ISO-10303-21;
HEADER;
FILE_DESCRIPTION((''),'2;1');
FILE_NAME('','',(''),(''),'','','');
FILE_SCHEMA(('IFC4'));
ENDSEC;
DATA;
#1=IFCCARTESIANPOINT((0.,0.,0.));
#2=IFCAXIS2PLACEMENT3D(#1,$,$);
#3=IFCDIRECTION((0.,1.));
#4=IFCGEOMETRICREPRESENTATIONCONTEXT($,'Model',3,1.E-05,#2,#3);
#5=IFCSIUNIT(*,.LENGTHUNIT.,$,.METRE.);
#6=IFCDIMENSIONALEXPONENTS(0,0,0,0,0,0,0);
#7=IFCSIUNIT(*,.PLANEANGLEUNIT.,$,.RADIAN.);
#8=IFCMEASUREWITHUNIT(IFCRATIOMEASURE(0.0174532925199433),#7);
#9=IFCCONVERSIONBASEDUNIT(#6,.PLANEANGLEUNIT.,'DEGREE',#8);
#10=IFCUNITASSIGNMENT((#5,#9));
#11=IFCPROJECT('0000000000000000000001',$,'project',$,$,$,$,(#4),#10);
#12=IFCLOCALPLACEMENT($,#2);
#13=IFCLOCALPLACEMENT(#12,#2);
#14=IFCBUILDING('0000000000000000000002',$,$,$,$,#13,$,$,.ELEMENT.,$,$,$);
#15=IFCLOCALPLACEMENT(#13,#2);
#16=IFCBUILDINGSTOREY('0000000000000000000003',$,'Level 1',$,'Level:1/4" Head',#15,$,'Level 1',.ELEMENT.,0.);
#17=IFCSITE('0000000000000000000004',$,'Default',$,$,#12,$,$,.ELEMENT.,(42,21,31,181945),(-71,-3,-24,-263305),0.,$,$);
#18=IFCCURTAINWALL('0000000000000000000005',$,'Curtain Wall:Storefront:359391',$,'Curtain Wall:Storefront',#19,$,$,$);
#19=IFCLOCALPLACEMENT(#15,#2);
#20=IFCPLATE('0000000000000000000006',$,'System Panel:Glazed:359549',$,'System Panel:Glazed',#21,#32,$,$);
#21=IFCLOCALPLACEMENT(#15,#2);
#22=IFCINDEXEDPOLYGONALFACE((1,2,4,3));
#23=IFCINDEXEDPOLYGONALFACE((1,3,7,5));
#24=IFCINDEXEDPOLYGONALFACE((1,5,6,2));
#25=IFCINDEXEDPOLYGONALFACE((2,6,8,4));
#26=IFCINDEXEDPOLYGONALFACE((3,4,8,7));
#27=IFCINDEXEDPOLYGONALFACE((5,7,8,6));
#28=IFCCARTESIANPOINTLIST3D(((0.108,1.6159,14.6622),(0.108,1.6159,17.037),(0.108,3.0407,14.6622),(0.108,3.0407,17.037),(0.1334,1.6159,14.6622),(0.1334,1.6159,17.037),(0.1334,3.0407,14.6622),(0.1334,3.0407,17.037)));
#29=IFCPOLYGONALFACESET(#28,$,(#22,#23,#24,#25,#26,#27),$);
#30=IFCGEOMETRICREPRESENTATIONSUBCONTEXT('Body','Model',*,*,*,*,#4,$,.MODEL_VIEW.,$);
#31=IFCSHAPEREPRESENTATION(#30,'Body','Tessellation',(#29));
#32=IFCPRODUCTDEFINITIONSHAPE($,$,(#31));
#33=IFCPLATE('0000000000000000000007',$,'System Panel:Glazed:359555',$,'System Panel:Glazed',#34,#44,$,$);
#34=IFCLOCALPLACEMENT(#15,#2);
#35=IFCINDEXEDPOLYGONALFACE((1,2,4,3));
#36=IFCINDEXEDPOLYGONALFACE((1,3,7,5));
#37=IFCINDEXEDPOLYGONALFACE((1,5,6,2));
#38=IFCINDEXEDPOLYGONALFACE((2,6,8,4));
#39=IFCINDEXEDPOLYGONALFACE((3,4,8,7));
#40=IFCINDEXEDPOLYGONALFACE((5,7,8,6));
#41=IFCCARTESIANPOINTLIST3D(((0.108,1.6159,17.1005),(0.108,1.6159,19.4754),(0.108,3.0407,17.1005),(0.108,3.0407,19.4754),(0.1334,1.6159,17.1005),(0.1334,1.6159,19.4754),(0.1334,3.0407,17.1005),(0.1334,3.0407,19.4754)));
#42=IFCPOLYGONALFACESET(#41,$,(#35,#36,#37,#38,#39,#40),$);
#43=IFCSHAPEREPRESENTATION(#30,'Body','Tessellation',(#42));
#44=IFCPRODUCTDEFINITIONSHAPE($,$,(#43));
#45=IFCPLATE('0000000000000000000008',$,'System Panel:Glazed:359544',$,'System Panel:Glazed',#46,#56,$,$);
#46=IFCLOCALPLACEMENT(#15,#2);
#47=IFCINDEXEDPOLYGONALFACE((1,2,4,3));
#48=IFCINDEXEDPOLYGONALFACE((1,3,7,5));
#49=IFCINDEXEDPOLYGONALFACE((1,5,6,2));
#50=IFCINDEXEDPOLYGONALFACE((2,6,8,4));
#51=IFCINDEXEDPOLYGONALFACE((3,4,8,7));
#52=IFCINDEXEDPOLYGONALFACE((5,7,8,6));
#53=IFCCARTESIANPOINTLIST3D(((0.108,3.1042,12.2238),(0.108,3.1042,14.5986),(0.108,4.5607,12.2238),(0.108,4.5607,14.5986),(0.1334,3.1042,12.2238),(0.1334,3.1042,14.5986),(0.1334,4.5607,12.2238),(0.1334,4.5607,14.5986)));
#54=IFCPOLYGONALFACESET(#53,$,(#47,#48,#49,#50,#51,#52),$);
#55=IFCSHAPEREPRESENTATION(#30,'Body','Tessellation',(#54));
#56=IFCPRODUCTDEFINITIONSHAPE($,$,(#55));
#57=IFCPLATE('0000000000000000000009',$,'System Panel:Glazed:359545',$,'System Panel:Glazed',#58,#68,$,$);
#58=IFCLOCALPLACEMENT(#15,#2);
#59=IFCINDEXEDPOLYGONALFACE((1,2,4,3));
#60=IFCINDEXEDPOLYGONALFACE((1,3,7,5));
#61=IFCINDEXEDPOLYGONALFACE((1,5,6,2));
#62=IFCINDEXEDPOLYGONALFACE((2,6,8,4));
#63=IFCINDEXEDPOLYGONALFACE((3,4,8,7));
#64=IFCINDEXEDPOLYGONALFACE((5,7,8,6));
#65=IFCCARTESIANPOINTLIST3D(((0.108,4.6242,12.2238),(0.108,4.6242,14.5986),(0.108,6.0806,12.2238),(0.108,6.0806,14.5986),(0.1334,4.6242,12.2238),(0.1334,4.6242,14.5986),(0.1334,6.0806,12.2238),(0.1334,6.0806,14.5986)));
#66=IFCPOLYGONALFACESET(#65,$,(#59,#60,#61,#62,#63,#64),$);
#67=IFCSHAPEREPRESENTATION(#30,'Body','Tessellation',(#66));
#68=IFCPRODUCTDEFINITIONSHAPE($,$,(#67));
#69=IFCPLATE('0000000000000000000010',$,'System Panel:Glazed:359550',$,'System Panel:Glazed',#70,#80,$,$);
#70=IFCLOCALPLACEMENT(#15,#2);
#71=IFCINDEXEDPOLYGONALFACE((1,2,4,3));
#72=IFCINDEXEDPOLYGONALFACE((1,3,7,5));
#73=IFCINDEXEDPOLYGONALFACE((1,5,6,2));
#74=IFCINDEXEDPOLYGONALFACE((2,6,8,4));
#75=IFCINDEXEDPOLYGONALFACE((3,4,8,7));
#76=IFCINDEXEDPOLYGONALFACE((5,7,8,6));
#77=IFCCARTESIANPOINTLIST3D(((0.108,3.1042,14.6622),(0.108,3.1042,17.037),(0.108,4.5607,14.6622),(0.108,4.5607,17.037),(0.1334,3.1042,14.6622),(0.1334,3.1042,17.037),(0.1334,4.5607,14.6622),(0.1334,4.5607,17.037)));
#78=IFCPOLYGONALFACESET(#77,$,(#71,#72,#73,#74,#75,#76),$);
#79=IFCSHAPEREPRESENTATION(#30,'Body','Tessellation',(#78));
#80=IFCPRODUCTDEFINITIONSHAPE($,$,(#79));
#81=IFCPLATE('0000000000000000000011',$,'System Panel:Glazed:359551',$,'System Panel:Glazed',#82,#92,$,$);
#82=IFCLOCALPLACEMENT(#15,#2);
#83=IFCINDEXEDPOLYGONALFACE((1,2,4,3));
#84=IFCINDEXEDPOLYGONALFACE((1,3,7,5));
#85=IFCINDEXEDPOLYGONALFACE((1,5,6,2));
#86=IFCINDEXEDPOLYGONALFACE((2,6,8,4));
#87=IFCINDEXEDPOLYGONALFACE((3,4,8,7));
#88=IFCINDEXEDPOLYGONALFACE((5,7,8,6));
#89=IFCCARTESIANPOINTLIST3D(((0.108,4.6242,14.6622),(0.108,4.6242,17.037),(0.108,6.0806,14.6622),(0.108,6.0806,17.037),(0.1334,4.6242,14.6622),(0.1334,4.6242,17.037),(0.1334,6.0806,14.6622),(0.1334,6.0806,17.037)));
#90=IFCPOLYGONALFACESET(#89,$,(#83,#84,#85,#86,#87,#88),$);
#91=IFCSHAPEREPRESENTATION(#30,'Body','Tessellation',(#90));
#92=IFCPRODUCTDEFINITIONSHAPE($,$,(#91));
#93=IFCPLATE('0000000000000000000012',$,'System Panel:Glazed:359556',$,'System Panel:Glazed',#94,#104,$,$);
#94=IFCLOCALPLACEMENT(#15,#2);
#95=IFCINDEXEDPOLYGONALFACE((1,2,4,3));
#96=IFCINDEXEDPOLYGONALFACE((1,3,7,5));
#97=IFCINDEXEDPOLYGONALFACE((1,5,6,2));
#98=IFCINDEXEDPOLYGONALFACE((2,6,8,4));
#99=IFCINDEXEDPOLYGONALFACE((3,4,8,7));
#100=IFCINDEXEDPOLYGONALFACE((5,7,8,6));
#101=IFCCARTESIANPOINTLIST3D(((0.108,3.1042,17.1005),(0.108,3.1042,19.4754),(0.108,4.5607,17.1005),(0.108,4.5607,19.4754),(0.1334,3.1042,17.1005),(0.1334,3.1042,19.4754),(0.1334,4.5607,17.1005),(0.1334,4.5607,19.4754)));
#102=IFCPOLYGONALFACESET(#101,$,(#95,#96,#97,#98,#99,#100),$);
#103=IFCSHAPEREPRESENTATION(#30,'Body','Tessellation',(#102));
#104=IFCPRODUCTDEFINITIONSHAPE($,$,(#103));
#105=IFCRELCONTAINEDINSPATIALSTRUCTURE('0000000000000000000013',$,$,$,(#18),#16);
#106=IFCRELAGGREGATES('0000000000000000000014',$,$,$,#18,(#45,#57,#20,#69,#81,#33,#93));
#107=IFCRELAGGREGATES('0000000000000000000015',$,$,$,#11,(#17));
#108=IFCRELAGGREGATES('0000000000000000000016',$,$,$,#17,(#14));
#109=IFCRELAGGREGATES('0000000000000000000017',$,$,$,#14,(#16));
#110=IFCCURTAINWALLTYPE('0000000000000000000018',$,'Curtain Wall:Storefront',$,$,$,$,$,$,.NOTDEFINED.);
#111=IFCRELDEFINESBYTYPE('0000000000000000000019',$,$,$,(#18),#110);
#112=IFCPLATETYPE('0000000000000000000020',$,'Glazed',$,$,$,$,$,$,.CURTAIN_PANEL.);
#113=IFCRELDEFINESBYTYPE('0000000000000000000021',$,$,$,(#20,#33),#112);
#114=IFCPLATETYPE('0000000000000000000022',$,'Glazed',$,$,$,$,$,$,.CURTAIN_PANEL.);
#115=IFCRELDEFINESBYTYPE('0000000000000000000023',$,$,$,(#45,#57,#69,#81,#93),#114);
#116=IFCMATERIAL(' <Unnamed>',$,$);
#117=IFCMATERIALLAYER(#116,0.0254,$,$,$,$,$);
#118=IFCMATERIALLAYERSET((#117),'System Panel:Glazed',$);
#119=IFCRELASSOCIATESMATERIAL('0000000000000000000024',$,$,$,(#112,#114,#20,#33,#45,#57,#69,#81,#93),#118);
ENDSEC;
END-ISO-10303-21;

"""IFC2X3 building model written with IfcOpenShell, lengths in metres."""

from ifc_helpers import new_model, entity, si_unit, converted_unit, direction, frame, frame_2d, origin, place, context, subcontext, project, spatial, rectangle, extrude, source, transform, mapped, material, layer, layer_set, layer_usage, type_object, type_shapes, element, aggregate, save


model = new_model("IFC2X3")

# Units and contexts
model_context = context("Model", 3, precision=1e-05, world=origin(), true_north=direction((0.0, 1.0)))
body_context = subcontext(model_context, "Body", "Model", "MODEL_VIEW")
ifc_project = project(units=[si_unit("LENGTHUNIT", "METRE"), converted_unit("PLANEANGLEUNIT", "DEGREE", entity("IfcRatioMeasure", 0.0174532925199433), si_unit("PLANEANGLEUNIT", "RADIAN"), dimensions=[0, 0, 0, 0, 0, 0, 0])], contexts=[model_context])

# Site, building, storey
site_placement = place(None, origin())
site = spatial("IfcSite", under=ifc_project, at=site_placement, Name="Default", CompositionType="ELEMENT", RefLatitude=(42, 21, 31, 181945), RefLongitude=(-71, -3, -24, -263305), RefElevation=0.0)
building_placement = place(site_placement, origin())
building = spatial("IfcBuilding", under=site, at=building_placement, CompositionType="ELEMENT")
storey_placement = place(building_placement, origin())
storey = spatial("IfcBuildingStorey", under=building, at=storey_placement, Name="Level 1", ObjectType="Level:1/4\" Head", LongName="Level 1", CompositionType="ELEMENT", Elevation=0.0)

# Curtain wall, plates
curtain_wall_type = type_object("IfcCurtainWallType", Name="Curtain Wall:Storefront", PredefinedType="NOTDEFINED")
curtain_wall_placement = place(storey_placement, origin())
curtain_wall = element("IfcCurtainWall", 1, at=curtain_wall_placement, inside=storey, type_object=curtain_wall_type, Name="Curtain Wall:Storefront:359391", ObjectType="Curtain Wall:Storefront")
ifc_material_1 = material(Name=" <Unnamed>")
ifc_layer = layer(ifc_material_1, 0.0254)
ifc_layer_set = layer_set([ifc_layer], Name="System Panel:Glazed")
plate_type_1 = type_object("IfcPlateType", Name="Glazed", PredefinedType="CURTAIN_PANEL", material=ifc_layer_set)
shared_shape_1 = source(origin(), body_context, "Body", "SweptSolid", [
    extrude(rectangle(XDim=0.0254, YDim=1.4248, at=frame_2d((0.0, 0.0), x_axis=(1.0, 0.0))), frame((0.7124, 0.0127, 0.0), z_axis=(0.0, 0.0, 1.0), x_axis=(0.0, 1.0, 0.0)), (0.0, 0.0, 1.0), 2.3749),
])
type_shapes(plate_type_1, [shared_shape_1])
ifc_layer_usage_1 = layer_usage(ifc_layer_set, "AXIS3", "POSITIVE", 0.1042)
plate_1_placement = place(curtain_wall_placement, frame((0.1334, 1.6159, 14.6622), z_axis=(0.0, 0.0, 1.0), x_axis=(0.0, 1.0, 0.0)))
plate_1 = element("IfcPlate", 2, at=plate_1_placement, type_object=plate_type_1, material=ifc_layer_usage_1, Name="System Panel:Glazed:359549", ObjectType="System Panel:Glazed", context=body_context, shape_type="MappedRepresentation", body=[
    mapped(shared_shape_1, transform((0.0, 0.0, 0.0), scale=1.0)),
])
ifc_layer_usage_2 = layer_usage(ifc_layer_set, "AXIS3", "POSITIVE", 0.1042)
plate_2_placement = place(curtain_wall_placement, frame((0.1334, 1.6159, 17.1005), z_axis=(0.0, 0.0, 1.0), x_axis=(0.0, 1.0, 0.0)))
plate_2 = element("IfcPlate", 3, at=plate_2_placement, type_object=plate_type_1, material=ifc_layer_usage_2, Name="System Panel:Glazed:359555", ObjectType="System Panel:Glazed", context=body_context, shape_type="MappedRepresentation", body=[
    mapped(shared_shape_1, transform((0.0, 0.0, 0.0), scale=1.0)),
])
ifc_layer_usage_3 = layer_usage(ifc_layer_set, "AXIS3", "POSITIVE", 0.1042)
plate_type_2 = type_object("IfcPlateType", Name="Glazed", PredefinedType="CURTAIN_PANEL", material=ifc_layer_set)
shared_shape_2 = source(origin(), body_context, "Body", "SweptSolid", [
    extrude(rectangle(XDim=0.0254, YDim=1.4565, at=frame_2d((0.0, 0.0), x_axis=(1.0, 0.0))), frame((0.7282, 0.0127, 0.0), z_axis=(0.0, 0.0, 1.0), x_axis=(0.0, 1.0, 0.0)), (0.0, 0.0, 1.0), 2.3749),
])
type_shapes(plate_type_2, [shared_shape_2])
plate_3_placement = place(curtain_wall_placement, frame((0.1334, 3.1042, 12.2238), z_axis=(0.0, 0.0, 1.0), x_axis=(0.0, 1.0, 0.0)))
plate_3 = element("IfcPlate", 4, at=plate_3_placement, type_object=plate_type_2, material=ifc_layer_usage_3, Name="System Panel:Glazed:359544", ObjectType="System Panel:Glazed", context=body_context, shape_type="MappedRepresentation", body=[
    mapped(shared_shape_2, transform((0.0, 0.0, 0.0), scale=1.0)),
])
ifc_layer_usage_4 = layer_usage(ifc_layer_set, "AXIS3", "POSITIVE", 0.1042)
plate_4_placement = place(curtain_wall_placement, frame((0.1334, 4.6242, 12.2238), z_axis=(0.0, 0.0, 1.0), x_axis=(0.0, 1.0, 0.0)))
plate_4 = element("IfcPlate", 5, at=plate_4_placement, type_object=plate_type_2, material=ifc_layer_usage_4, Name="System Panel:Glazed:359545", ObjectType="System Panel:Glazed", context=body_context, shape_type="MappedRepresentation", body=[
    mapped(shared_shape_2, transform((0.0, 0.0, 0.0), scale=1.0)),
])
ifc_layer_usage_5 = layer_usage(ifc_layer_set, "AXIS3", "POSITIVE", 0.1042)
plate_5_placement = place(curtain_wall_placement, frame((0.1334, 3.1042, 14.6622), z_axis=(0.0, 0.0, 1.0), x_axis=(0.0, 1.0, 0.0)))
plate_5 = element("IfcPlate", 6, at=plate_5_placement, type_object=plate_type_2, material=ifc_layer_usage_5, Name="System Panel:Glazed:359550", ObjectType="System Panel:Glazed", context=body_context, shape_type="MappedRepresentation", body=[
    mapped(shared_shape_2, transform((0.0, 0.0, 0.0), scale=1.0)),
])
ifc_layer_usage_6 = layer_usage(ifc_layer_set, "AXIS3", "POSITIVE", 0.1042)
plate_6_placement = place(curtain_wall_placement, frame((0.1334, 4.6242, 14.6622), z_axis=(0.0, 0.0, 1.0), x_axis=(0.0, 1.0, 0.0)))
plate_6 = element("IfcPlate", 7, at=plate_6_placement, type_object=plate_type_2, material=ifc_layer_usage_6, Name="System Panel:Glazed:359551", ObjectType="System Panel:Glazed", context=body_context, shape_type="MappedRepresentation", body=[
    mapped(shared_shape_2, transform((0.0, 0.0, 0.0), scale=1.0)),
])
ifc_layer_usage_7 = layer_usage(ifc_layer_set, "AXIS3", "POSITIVE", 0.1042)
plate_7_placement = place(curtain_wall_placement, frame((0.1334, 3.1042, 17.1005), z_axis=(0.0, 0.0, 1.0), x_axis=(0.0, 1.0, 0.0)))
plate_7 = element("IfcPlate", 8, at=plate_7_placement, type_object=plate_type_2, material=ifc_layer_usage_7, Name="System Panel:Glazed:359556", ObjectType="System Panel:Glazed", context=body_context, shape_type="MappedRepresentation", body=[
    mapped(shared_shape_2, transform((0.0, 0.0, 0.0), scale=1.0)),
])
aggregate(curtain_wall, [plate_3, plate_4, plate_1, plate_5, plate_6, plate_2, plate_7])

save(model, "model.ifc")
